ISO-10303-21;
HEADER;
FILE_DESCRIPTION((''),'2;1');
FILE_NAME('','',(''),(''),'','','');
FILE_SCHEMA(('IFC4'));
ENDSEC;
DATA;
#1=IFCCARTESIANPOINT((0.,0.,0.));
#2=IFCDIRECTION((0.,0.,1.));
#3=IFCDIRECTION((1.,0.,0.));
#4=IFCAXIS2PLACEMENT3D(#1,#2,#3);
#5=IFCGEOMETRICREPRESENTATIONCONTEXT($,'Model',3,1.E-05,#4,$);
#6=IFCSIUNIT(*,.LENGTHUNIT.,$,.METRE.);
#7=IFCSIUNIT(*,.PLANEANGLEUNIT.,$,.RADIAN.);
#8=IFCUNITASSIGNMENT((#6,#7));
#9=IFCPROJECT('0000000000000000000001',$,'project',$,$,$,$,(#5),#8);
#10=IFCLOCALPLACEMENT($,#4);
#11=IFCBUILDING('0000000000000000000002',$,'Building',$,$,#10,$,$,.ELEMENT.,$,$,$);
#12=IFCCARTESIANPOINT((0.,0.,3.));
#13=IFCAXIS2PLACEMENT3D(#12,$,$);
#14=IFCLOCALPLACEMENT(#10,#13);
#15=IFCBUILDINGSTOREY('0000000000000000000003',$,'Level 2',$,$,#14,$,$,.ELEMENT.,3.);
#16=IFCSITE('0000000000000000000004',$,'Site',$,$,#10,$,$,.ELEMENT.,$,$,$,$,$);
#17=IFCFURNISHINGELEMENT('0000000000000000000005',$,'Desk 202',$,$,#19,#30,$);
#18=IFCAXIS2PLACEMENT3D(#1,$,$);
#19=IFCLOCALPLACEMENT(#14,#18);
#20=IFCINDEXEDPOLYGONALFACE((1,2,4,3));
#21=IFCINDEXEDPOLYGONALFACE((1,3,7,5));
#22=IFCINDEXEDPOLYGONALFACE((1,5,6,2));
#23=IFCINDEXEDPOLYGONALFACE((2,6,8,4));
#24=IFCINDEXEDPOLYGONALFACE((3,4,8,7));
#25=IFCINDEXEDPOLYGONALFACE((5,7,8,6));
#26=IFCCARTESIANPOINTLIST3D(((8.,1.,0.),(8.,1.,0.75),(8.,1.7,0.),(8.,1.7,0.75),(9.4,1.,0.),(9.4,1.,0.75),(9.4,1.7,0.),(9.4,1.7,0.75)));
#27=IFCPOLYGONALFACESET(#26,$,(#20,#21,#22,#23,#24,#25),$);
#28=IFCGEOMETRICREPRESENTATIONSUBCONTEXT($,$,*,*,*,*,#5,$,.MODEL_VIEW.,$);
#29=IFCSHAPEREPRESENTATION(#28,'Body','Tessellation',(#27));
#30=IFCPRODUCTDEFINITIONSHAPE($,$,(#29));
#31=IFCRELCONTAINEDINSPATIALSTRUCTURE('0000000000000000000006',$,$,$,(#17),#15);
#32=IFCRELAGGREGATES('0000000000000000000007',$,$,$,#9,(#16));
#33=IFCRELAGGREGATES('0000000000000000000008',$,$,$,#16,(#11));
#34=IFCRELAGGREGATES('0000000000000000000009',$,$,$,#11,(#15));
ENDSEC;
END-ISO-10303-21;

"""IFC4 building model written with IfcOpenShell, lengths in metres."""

from ifc_helpers import new_model, si_unit, frame, frame_2d, origin, origin_with_axes, place, context, subcontext, project, spatial, rectangle, extrude, element, save


model = new_model("IFC4")

# Units and contexts
model_context = context("Model", 3, precision=1e-05, world=origin_with_axes())
sub_context = subcontext(model_context, None, None, "MODEL_VIEW")
ifc_project = project(units=[si_unit("LENGTHUNIT", "METRE"), si_unit("PLANEANGLEUNIT", "RADIAN")], contexts=[model_context])

# Site, building, storey
placement = place(None, origin_with_axes())
site = spatial("IfcSite", under=ifc_project, at=placement, Name="Site", CompositionType="ELEMENT")
building = spatial("IfcBuilding", under=site, at=placement, Name="Building", CompositionType="ELEMENT")
storey_placement = place(placement, frame((0.0, 0.0, 3.0)))
storey = spatial("IfcBuildingStorey", under=building, at=storey_placement, Name="Level 2", CompositionType="ELEMENT", Elevation=3.0)

# Furnishing element
for number, where, name in (
    (1, (8.0, 1.0, 3.0), "Desk 202"),
):
    element("IfcFurnishingElement", number, at=place(placement, frame(where)), inside=storey, Name=name, context=sub_context, shape_type="SweptSolid", body=[
        extrude(rectangle(XDim=1.4, YDim=0.7, at=frame_2d((0.7, 0.35))), origin(), (0.0, 0.0, 1.0), 0.75),
    ])

save(model, "model.ifc")
